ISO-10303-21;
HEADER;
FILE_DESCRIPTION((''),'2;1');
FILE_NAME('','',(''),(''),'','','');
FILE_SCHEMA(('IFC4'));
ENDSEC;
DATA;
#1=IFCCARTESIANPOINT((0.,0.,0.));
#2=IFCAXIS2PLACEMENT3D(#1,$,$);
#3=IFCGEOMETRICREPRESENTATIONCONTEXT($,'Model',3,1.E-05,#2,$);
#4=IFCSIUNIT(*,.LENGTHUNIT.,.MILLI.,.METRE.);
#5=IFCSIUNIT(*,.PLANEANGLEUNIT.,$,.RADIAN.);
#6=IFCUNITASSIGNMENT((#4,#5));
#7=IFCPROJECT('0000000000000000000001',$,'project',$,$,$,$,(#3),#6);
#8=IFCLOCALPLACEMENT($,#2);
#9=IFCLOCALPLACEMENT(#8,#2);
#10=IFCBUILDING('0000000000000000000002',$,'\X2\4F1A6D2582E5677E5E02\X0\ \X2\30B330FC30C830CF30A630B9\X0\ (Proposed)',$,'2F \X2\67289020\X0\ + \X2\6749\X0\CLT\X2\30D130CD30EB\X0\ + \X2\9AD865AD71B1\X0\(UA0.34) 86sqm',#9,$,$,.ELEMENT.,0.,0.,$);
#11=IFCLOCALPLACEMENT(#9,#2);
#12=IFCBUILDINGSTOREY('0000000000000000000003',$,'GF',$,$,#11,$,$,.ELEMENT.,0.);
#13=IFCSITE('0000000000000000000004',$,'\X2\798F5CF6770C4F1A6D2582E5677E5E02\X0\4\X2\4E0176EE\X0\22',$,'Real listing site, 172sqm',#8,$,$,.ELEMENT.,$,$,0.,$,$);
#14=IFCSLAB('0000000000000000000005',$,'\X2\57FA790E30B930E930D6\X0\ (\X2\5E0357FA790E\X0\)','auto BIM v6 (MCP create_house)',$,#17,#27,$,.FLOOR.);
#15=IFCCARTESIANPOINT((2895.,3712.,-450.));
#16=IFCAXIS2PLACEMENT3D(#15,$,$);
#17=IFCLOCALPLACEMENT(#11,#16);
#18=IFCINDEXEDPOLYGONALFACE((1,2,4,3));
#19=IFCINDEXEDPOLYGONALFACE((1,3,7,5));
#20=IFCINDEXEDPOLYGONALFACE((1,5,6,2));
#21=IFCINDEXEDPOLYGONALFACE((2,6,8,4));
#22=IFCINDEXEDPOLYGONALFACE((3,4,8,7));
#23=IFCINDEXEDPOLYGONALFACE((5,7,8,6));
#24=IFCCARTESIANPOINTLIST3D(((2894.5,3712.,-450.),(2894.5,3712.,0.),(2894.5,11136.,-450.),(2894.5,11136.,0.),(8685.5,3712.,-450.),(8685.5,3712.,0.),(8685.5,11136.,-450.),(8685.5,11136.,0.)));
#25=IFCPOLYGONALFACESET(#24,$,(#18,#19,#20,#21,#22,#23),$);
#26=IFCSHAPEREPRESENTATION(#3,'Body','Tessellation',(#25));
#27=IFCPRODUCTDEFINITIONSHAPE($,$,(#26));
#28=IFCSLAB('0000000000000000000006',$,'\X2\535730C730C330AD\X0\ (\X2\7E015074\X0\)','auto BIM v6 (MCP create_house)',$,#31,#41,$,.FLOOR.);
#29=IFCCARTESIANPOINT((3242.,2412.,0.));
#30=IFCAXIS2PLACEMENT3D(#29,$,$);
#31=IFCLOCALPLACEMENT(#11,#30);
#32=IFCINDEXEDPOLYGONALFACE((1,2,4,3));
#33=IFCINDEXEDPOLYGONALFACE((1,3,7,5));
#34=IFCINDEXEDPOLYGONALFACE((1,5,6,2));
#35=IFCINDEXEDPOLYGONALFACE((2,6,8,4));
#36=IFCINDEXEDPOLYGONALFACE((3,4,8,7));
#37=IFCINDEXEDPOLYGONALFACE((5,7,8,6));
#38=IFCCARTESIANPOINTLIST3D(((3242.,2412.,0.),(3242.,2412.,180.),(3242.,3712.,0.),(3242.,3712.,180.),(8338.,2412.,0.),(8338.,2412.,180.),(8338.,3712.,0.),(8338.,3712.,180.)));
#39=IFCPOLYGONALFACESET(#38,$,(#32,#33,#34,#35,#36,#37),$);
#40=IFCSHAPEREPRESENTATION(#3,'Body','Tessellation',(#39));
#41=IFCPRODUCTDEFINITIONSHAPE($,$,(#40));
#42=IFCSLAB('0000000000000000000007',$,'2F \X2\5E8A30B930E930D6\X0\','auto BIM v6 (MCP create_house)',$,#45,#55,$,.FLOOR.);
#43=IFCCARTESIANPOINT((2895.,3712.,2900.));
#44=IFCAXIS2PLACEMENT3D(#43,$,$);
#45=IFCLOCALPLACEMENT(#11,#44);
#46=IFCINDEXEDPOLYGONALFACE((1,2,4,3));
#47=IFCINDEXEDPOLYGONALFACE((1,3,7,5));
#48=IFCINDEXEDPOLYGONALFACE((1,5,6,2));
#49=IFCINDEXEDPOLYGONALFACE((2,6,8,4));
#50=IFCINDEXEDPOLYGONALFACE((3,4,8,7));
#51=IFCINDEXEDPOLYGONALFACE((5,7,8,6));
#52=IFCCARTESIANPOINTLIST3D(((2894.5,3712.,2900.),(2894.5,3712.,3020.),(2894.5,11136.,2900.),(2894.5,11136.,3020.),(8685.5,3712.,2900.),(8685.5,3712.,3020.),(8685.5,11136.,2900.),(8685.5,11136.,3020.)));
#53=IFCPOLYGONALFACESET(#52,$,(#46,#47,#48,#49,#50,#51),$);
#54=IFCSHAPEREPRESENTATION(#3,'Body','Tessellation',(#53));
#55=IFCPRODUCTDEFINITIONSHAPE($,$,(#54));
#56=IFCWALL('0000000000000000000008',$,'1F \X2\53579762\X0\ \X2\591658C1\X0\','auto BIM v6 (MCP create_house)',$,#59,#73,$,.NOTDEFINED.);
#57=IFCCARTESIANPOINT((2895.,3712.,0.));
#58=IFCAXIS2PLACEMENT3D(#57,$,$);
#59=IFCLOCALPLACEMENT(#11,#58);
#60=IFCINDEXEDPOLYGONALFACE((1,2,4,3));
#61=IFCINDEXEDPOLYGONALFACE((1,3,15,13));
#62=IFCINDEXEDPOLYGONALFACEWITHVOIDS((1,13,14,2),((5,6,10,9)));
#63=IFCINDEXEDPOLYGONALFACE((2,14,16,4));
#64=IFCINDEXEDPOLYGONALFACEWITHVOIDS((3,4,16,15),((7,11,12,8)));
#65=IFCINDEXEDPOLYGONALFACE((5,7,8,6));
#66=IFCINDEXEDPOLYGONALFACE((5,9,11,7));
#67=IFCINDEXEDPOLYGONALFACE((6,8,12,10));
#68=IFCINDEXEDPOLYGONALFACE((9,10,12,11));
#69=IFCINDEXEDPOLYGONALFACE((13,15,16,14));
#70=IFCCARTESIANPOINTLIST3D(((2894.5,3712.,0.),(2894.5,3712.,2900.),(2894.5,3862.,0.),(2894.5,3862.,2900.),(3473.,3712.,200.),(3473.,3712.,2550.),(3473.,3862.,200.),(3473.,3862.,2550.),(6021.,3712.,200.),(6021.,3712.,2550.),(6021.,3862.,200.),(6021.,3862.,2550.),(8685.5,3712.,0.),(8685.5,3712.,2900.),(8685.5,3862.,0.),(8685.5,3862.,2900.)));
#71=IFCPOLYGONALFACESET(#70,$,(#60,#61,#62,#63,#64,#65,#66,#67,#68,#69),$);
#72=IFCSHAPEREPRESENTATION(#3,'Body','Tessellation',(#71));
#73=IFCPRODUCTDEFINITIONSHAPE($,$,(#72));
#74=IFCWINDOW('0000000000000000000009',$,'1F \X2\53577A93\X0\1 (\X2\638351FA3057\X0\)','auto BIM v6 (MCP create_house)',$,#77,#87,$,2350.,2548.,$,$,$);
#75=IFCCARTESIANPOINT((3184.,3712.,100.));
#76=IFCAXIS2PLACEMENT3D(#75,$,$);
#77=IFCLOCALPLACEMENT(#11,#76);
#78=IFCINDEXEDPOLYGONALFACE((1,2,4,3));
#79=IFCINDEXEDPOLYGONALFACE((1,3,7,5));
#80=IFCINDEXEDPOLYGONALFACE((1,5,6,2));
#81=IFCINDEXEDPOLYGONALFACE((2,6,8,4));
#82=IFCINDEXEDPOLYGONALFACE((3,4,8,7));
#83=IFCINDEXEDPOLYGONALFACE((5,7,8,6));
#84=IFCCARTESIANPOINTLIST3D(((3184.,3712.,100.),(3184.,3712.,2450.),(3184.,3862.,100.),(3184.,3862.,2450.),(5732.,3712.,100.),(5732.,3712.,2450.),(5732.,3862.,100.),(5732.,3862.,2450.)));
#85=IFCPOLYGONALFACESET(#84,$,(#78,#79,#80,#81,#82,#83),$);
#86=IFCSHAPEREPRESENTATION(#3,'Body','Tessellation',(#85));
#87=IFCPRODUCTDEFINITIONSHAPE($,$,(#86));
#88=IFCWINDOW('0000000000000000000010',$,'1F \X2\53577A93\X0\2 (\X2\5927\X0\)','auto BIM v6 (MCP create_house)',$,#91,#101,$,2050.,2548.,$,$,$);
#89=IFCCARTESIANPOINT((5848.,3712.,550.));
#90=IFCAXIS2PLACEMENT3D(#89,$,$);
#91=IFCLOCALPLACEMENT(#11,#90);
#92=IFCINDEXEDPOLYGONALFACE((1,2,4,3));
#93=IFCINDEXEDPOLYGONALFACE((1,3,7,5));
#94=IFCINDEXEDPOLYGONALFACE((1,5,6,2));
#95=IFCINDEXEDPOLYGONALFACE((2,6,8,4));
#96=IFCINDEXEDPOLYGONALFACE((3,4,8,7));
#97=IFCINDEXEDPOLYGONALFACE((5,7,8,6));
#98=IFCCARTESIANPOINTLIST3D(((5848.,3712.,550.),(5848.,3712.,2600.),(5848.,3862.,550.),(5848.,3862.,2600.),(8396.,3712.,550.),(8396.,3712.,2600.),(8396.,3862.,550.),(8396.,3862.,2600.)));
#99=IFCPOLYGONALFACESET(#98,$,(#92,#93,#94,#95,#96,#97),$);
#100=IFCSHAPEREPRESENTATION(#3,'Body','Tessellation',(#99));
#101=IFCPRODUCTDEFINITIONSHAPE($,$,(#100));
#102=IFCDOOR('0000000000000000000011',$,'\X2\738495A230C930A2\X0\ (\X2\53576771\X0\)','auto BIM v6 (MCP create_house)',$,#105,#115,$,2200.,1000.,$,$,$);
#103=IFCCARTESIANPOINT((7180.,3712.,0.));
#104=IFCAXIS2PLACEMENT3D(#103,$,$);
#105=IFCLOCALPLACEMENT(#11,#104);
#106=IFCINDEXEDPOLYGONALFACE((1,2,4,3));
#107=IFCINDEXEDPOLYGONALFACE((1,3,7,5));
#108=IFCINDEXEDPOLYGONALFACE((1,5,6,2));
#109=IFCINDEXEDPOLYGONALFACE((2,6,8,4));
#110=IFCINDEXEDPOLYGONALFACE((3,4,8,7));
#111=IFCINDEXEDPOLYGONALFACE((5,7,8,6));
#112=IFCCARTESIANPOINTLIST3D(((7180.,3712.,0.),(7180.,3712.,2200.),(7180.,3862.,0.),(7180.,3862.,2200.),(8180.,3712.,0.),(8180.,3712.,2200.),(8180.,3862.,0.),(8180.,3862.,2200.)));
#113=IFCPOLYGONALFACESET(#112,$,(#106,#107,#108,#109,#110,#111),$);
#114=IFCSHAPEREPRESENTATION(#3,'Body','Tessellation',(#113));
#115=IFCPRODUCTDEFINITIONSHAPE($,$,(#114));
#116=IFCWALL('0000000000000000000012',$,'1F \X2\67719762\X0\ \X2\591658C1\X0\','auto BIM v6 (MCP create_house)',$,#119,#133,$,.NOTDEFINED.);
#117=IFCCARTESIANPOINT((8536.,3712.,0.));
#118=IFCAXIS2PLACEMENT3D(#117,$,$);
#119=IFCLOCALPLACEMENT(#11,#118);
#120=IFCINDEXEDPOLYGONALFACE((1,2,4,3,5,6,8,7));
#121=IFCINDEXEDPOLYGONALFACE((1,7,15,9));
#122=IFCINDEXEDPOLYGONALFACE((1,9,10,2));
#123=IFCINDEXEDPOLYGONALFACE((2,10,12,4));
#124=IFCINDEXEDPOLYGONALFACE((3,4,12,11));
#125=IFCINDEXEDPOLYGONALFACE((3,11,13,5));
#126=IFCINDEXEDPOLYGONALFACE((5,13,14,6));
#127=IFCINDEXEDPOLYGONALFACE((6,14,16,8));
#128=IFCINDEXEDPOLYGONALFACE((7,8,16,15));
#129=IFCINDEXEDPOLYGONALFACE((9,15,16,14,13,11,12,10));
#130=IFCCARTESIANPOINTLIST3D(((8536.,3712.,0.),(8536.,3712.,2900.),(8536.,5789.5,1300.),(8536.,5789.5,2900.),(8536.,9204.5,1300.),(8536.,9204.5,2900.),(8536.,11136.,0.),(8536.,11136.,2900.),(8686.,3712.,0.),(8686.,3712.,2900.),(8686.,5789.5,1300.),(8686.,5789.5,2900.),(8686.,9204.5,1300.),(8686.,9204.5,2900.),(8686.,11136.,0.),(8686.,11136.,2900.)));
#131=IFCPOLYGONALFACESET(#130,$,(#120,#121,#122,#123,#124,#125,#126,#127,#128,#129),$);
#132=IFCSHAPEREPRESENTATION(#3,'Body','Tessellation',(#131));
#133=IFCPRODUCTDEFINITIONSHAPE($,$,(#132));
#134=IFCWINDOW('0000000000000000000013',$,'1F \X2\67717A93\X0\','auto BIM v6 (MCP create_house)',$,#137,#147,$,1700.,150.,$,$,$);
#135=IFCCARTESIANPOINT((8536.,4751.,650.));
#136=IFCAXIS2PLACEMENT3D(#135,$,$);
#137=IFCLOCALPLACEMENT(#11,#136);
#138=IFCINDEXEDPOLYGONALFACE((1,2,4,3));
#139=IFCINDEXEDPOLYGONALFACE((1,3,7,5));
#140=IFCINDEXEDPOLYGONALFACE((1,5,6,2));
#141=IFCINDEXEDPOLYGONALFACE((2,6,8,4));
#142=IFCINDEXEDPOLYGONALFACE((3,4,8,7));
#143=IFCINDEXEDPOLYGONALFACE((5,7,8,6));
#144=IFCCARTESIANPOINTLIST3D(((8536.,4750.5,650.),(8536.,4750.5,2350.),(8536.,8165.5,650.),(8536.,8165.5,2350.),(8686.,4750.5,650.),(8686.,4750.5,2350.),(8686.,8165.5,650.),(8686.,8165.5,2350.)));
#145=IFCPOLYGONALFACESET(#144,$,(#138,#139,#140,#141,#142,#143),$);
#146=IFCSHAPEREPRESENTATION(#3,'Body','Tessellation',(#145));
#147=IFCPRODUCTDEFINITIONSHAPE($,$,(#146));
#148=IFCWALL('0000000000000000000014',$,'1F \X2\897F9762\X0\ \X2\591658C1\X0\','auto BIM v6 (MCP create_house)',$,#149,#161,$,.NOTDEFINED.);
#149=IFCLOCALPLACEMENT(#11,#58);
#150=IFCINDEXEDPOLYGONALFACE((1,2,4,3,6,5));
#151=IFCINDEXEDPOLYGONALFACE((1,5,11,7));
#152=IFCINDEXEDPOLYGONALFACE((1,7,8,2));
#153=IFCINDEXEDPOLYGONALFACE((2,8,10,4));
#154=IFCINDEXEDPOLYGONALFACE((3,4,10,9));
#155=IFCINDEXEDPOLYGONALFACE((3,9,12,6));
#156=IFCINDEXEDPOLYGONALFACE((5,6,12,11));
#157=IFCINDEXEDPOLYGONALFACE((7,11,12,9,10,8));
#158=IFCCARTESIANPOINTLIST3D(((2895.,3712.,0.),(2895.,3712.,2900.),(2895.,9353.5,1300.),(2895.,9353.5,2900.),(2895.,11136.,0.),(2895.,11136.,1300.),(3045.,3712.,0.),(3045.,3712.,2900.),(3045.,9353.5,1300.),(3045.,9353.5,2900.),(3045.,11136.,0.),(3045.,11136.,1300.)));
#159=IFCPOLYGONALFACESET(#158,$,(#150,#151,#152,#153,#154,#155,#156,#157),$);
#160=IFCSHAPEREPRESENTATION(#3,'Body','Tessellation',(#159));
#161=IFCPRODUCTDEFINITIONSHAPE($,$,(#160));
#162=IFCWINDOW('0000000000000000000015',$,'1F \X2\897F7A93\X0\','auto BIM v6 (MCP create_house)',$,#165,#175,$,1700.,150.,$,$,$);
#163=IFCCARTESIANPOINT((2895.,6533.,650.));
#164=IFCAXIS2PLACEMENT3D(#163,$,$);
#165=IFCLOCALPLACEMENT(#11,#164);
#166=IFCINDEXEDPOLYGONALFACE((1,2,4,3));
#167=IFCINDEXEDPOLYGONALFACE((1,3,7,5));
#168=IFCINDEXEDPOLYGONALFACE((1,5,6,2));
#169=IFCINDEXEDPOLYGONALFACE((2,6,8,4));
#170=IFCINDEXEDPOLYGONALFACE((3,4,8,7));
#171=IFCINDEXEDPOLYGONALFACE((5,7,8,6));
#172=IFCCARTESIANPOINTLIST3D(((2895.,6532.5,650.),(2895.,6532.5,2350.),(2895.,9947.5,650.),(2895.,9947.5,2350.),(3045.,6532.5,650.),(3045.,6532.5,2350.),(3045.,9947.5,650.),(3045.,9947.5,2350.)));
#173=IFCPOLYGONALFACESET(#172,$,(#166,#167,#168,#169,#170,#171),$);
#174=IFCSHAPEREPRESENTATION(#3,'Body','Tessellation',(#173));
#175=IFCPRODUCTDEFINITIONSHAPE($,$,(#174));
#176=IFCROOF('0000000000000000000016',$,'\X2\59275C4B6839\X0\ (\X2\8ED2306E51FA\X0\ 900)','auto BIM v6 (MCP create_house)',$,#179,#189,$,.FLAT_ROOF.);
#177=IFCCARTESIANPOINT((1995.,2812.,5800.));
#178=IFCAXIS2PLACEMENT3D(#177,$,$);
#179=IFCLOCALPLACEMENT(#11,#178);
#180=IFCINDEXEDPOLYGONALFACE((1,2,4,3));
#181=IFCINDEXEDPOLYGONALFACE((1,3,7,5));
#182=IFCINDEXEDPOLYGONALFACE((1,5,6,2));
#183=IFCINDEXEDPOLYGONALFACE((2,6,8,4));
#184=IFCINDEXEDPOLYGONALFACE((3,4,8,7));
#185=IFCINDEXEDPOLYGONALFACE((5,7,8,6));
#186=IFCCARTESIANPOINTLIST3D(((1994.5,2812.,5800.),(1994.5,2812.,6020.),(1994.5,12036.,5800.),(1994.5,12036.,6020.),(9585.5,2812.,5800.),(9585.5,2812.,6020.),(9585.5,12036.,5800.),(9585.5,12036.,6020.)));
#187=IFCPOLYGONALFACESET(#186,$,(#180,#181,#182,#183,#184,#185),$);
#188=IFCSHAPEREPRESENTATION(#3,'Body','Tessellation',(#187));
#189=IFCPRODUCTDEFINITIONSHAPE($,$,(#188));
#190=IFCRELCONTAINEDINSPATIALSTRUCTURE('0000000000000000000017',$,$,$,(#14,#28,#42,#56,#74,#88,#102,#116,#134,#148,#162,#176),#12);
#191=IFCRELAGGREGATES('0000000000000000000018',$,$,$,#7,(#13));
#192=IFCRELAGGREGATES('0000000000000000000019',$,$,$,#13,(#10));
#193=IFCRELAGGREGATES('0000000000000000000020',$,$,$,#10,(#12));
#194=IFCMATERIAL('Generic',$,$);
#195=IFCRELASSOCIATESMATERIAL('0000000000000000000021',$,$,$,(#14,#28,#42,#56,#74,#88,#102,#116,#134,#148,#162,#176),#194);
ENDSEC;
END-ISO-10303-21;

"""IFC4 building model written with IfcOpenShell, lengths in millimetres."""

from ifc_helpers import new_model, si_unit, frame, frame_2d, origin, place, context, project, spatial, rectangle, extrude, material, element, fill, save


model = new_model("IFC4")

# Units and contexts
model_context = context("Model", 3, precision=1e-05, world=origin())
ifc_project = project(units=[si_unit("LENGTHUNIT", "METRE", prefix="MILLI"), si_unit("PLANEANGLEUNIT", "RADIAN")], contexts=[model_context])

# Site, building, storey
site_placement = place(None, origin())
site = spatial("IfcSite", under=ifc_project, at=site_placement, Name="福島県会津若松市4丁目22", ObjectType="Real listing site, 172sqm", CompositionType="ELEMENT", RefElevation=0.0)
building_placement = place(site_placement, origin())
building = spatial("IfcBuilding", under=site, at=building_placement, Name="会津若松市 コートハウス (Proposed)", ObjectType="2F 木造 + 杉CLTパネル + 高断熱(UA0.34) 86sqm", CompositionType="ELEMENT", ElevationOfRefHeight=0.0, ElevationOfTerrain=0.0)
storey_placement = place(building_placement, origin())
storey = spatial("IfcBuildingStorey", under=building, at=storey_placement, Name="GF", CompositionType="ELEMENT", Elevation=0.0)

# Slabs
ifc_material = material(Name="Generic")
slab_1_placement = place(storey_placement, frame((2895.0, 3712.0, -450.0)))
element("IfcSlab", 1, at=slab_1_placement, inside=storey, material=ifc_material, Name="基礎スラブ (布基礎)", Description="auto BIM v6 (MCP create_house)", PredefinedType="FLOOR", context=model_context, shape_type="SweptSolid", body=[
    extrude(rectangle(XDim=5791.0, YDim=7424.0, at=frame_2d((2895.0, 3712.0))), frame((2895.0, 3712.0, -450.0)), (0.0, 0.0, 1.0), 450.0),
])
slab_2_placement = place(storey_placement, frame((3242.0, 2412.0, 0.0)))
element("IfcSlab", 2, at=slab_2_placement, inside=storey, material=ifc_material, Name="南デッキ (縁側)", Description="auto BIM v6 (MCP create_house)", PredefinedType="FLOOR", context=model_context, shape_type="SweptSolid", body=[
    extrude(rectangle(XDim=5096.0, YDim=1300.0, at=frame_2d((2548.0, 650.0))), frame((3242.0, 2412.0, 0.0)), (0.0, 0.0, 1.0), 180.0),
])
slab_3_placement = place(storey_placement, frame((2895.0, 3712.0, 2900.0)))
element("IfcSlab", 3, at=slab_3_placement, inside=storey, material=ifc_material, Name="2F 床スラブ", Description="auto BIM v6 (MCP create_house)", PredefinedType="FLOOR", context=model_context, shape_type="SweptSolid", body=[
    extrude(rectangle(XDim=5791.0, YDim=7424.0, at=frame_2d((2895.0, 3712.0))), frame((2895.0, 3712.0, 2900.0)), (0.0, 0.0, 1.0), 120.0),
])

# Wall, openings, windows, door
wall_1_placement = place(storey_placement, frame((2895.0, 3712.0, 0.0)))
wall_1 = element("IfcWall", 4, at=wall_1_placement, inside=storey, material=ifc_material, Name="1F 南面 外壁", Description="auto BIM v6 (MCP create_house)", PredefinedType="NOTDEFINED", context=model_context, shape_type="SweptSolid", body=[
    extrude(rectangle(XDim=5791.0, YDim=150.0, at=frame_2d((2895.0, 75.0))), frame((2895.0, 3712.0, 0.0)), (0.0, 0.0, 1.0), 2900.0),
])
opening_1_placement = place(storey_placement, frame((3184.0, 3712.0, 100.0)))
opening_1 = element("IfcOpeningElement", 5, at=opening_1_placement, cuts=wall_1, PredefinedType="NOTDEFINED", context=model_context, shape_type="SweptSolid", body=[
    extrude(rectangle(XDim=2548.0, YDim=150.0, at=frame_2d((1274.0, 75.0))), frame((3184.0, 3712.0, 100.0)), (0.0, 0.0, 1.0), 2350.0),
])
opening_2_placement = place(storey_placement, frame((5848.0, 3712.0, 550.0)))
opening_2 = element("IfcOpeningElement", 6, at=opening_2_placement, cuts=wall_1, PredefinedType="NOTDEFINED", context=model_context, shape_type="SweptSolid", body=[
    extrude(rectangle(XDim=2548.0, YDim=150.0, at=frame_2d((1274.0, 75.0))), frame((5848.0, 3712.0, 550.0)), (0.0, 0.0, 1.0), 2050.0),
])
opening_3_placement = place(storey_placement, frame((7180.0, 3712.0, 0.0)))
opening_3 = element("IfcOpeningElement", 7, at=opening_3_placement, cuts=wall_1, PredefinedType="NOTDEFINED", context=model_context, shape_type="SweptSolid", body=[
    extrude(rectangle(XDim=1000.0, YDim=150.0, at=frame_2d((500.0, 75.0))), frame((7180.0, 3712.0, 0.0)), (0.0, 0.0, 1.0), 2200.0),
])
window_1_placement = place(storey_placement, frame((3184.0, 3712.0, 100.0)))
window_1 = element("IfcWindow", 8, at=window_1_placement, inside=storey, material=ifc_material, Name="1F 南窓1 (掃出し)", Description="auto BIM v6 (MCP create_house)", OverallHeight=2350.0, OverallWidth=2548.0, context=model_context, shape_type="SweptSolid", body=[
    extrude(rectangle(XDim=2548.0, YDim=150.0, at=frame_2d((1274.0, 75.0))), frame((3184.0, 3712.0, 100.0)), (0.0, 0.0, 1.0), 2350.0),
])
fill(opening_1, window_1)
window_2_placement = place(storey_placement, frame((5848.0, 3712.0, 550.0)))
window_2 = element("IfcWindow", 9, at=window_2_placement, inside=storey, material=ifc_material, Name="1F 南窓2 (大)", Description="auto BIM v6 (MCP create_house)", OverallHeight=2050.0, OverallWidth=2548.0, context=model_context, shape_type="SweptSolid", body=[
    extrude(rectangle(XDim=2548.0, YDim=150.0, at=frame_2d((1274.0, 75.0))), frame((5848.0, 3712.0, 550.0)), (0.0, 0.0, 1.0), 2050.0),
])
fill(opening_2, window_2)
door_placement = place(storey_placement, frame((7180.0, 3712.0, 0.0)))
door = element("IfcDoor", 10, at=door_placement, inside=storey, material=ifc_material, Name="玄関ドア (南東)", Description="auto BIM v6 (MCP create_house)", OverallHeight=2200.0, OverallWidth=1000.0, context=model_context, shape_type="SweptSolid", body=[
    extrude(rectangle(XDim=1000.0, YDim=150.0, at=frame_2d((500.0, 75.0))), frame((7180.0, 3712.0, 0.0)), (0.0, 0.0, 1.0), 2200.0),
])
fill(opening_3, door)

# Walls, openings, windows
wall_2_placement = place(storey_placement, frame((8536.0, 3712.0, 0.0)))
wall_2 = element("IfcWall", 11, at=wall_2_placement, inside=storey, material=ifc_material, Name="1F 東面 外壁", Description="auto BIM v6 (MCP create_house)", PredefinedType="NOTDEFINED", context=model_context, shape_type="SweptSolid", body=[
    extrude(rectangle(XDim=150.0, YDim=7424.0, at=frame_2d((75.0, 3712.0))), frame((8536.0, 3712.0, 0.0)), (0.0, 0.0, 1.0), 2900.0),
])
opening_4_placement = place(storey_placement, frame((8536.0, 4751.0, 650.0)))
opening_4 = element("IfcOpeningElement", 12, at=opening_4_placement, cuts=wall_2, PredefinedType="NOTDEFINED", context=model_context, shape_type="SweptSolid", body=[
    extrude(rectangle(XDim=150.0, YDim=3415.0, at=frame_2d((75.0, 1707.0))), frame((8536.0, 4751.0, 650.0)), (0.0, 0.0, 1.0), 1700.0),
])
window_3_placement = place(storey_placement, frame((8536.0, 4751.0, 650.0)))
window_3 = element("IfcWindow", 13, at=window_3_placement, inside=storey, material=ifc_material, Name="1F 東窓", Description="auto BIM v6 (MCP create_house)", OverallHeight=1700.0, OverallWidth=150.0, context=model_context, shape_type="SweptSolid", body=[
    extrude(rectangle(XDim=150.0, YDim=3415.0, at=frame_2d((75.0, 1707.0))), frame((8536.0, 4751.0, 650.0)), (0.0, 0.0, 1.0), 1700.0),
])
fill(opening_4, window_3)
wall_3_placement = place(storey_placement, frame((2895.0, 3712.0, 0.0)))
wall_3 = element("IfcWall", 14, at=wall_3_placement, inside=storey, material=ifc_material, Name="1F 西面 外壁", Description="auto BIM v6 (MCP create_house)", PredefinedType="NOTDEFINED", context=model_context, shape_type="SweptSolid", body=[
    extrude(rectangle(XDim=150.0, YDim=7424.0, at=frame_2d((75.0, 3712.0))), frame((2895.0, 3712.0, 0.0)), (0.0, 0.0, 1.0), 2900.0),
])
opening_5_placement = place(storey_placement, frame((2895.0, 6533.0, 650.0)))
opening_5 = element("IfcOpeningElement", 15, at=opening_5_placement, cuts=wall_3, PredefinedType="NOTDEFINED", context=model_context, shape_type="SweptSolid", body=[
    extrude(rectangle(XDim=150.0, YDim=3415.0, at=frame_2d((75.0, 1707.0))), frame((2895.0, 6533.0, 650.0)), (0.0, 0.0, 1.0), 1700.0),
])
window_4_placement = place(storey_placement, frame((2895.0, 6533.0, 650.0)))
window_4 = element("IfcWindow", 16, at=window_4_placement, inside=storey, material=ifc_material, Name="1F 西窓", Description="auto BIM v6 (MCP create_house)", OverallHeight=1700.0, OverallWidth=150.0, context=model_context, shape_type="SweptSolid", body=[
    extrude(rectangle(XDim=150.0, YDim=3415.0, at=frame_2d((75.0, 1707.0))), frame((2895.0, 6533.0, 650.0)), (0.0, 0.0, 1.0), 1700.0),
])
fill(opening_5, window_4)

# Roof
roof_placement = place(storey_placement, frame((1995.0, 2812.0, 5800.0)))
element("IfcRoof", 17, at=roof_placement, inside=storey, material=ifc_material, Name="大屋根 (軒の出 900)", Description="auto BIM v6 (MCP create_house)", PredefinedType="FLAT_ROOF", context=model_context, shape_type="SweptSolid", body=[
    extrude(rectangle(XDim=7591.0, YDim=9224.0, at=frame_2d((3795.0, 4612.0))), frame((1995.0, 2812.0, 5800.0)), (0.0, 0.0, 1.0), 220.0),
])

save(model, "model.ifc")
